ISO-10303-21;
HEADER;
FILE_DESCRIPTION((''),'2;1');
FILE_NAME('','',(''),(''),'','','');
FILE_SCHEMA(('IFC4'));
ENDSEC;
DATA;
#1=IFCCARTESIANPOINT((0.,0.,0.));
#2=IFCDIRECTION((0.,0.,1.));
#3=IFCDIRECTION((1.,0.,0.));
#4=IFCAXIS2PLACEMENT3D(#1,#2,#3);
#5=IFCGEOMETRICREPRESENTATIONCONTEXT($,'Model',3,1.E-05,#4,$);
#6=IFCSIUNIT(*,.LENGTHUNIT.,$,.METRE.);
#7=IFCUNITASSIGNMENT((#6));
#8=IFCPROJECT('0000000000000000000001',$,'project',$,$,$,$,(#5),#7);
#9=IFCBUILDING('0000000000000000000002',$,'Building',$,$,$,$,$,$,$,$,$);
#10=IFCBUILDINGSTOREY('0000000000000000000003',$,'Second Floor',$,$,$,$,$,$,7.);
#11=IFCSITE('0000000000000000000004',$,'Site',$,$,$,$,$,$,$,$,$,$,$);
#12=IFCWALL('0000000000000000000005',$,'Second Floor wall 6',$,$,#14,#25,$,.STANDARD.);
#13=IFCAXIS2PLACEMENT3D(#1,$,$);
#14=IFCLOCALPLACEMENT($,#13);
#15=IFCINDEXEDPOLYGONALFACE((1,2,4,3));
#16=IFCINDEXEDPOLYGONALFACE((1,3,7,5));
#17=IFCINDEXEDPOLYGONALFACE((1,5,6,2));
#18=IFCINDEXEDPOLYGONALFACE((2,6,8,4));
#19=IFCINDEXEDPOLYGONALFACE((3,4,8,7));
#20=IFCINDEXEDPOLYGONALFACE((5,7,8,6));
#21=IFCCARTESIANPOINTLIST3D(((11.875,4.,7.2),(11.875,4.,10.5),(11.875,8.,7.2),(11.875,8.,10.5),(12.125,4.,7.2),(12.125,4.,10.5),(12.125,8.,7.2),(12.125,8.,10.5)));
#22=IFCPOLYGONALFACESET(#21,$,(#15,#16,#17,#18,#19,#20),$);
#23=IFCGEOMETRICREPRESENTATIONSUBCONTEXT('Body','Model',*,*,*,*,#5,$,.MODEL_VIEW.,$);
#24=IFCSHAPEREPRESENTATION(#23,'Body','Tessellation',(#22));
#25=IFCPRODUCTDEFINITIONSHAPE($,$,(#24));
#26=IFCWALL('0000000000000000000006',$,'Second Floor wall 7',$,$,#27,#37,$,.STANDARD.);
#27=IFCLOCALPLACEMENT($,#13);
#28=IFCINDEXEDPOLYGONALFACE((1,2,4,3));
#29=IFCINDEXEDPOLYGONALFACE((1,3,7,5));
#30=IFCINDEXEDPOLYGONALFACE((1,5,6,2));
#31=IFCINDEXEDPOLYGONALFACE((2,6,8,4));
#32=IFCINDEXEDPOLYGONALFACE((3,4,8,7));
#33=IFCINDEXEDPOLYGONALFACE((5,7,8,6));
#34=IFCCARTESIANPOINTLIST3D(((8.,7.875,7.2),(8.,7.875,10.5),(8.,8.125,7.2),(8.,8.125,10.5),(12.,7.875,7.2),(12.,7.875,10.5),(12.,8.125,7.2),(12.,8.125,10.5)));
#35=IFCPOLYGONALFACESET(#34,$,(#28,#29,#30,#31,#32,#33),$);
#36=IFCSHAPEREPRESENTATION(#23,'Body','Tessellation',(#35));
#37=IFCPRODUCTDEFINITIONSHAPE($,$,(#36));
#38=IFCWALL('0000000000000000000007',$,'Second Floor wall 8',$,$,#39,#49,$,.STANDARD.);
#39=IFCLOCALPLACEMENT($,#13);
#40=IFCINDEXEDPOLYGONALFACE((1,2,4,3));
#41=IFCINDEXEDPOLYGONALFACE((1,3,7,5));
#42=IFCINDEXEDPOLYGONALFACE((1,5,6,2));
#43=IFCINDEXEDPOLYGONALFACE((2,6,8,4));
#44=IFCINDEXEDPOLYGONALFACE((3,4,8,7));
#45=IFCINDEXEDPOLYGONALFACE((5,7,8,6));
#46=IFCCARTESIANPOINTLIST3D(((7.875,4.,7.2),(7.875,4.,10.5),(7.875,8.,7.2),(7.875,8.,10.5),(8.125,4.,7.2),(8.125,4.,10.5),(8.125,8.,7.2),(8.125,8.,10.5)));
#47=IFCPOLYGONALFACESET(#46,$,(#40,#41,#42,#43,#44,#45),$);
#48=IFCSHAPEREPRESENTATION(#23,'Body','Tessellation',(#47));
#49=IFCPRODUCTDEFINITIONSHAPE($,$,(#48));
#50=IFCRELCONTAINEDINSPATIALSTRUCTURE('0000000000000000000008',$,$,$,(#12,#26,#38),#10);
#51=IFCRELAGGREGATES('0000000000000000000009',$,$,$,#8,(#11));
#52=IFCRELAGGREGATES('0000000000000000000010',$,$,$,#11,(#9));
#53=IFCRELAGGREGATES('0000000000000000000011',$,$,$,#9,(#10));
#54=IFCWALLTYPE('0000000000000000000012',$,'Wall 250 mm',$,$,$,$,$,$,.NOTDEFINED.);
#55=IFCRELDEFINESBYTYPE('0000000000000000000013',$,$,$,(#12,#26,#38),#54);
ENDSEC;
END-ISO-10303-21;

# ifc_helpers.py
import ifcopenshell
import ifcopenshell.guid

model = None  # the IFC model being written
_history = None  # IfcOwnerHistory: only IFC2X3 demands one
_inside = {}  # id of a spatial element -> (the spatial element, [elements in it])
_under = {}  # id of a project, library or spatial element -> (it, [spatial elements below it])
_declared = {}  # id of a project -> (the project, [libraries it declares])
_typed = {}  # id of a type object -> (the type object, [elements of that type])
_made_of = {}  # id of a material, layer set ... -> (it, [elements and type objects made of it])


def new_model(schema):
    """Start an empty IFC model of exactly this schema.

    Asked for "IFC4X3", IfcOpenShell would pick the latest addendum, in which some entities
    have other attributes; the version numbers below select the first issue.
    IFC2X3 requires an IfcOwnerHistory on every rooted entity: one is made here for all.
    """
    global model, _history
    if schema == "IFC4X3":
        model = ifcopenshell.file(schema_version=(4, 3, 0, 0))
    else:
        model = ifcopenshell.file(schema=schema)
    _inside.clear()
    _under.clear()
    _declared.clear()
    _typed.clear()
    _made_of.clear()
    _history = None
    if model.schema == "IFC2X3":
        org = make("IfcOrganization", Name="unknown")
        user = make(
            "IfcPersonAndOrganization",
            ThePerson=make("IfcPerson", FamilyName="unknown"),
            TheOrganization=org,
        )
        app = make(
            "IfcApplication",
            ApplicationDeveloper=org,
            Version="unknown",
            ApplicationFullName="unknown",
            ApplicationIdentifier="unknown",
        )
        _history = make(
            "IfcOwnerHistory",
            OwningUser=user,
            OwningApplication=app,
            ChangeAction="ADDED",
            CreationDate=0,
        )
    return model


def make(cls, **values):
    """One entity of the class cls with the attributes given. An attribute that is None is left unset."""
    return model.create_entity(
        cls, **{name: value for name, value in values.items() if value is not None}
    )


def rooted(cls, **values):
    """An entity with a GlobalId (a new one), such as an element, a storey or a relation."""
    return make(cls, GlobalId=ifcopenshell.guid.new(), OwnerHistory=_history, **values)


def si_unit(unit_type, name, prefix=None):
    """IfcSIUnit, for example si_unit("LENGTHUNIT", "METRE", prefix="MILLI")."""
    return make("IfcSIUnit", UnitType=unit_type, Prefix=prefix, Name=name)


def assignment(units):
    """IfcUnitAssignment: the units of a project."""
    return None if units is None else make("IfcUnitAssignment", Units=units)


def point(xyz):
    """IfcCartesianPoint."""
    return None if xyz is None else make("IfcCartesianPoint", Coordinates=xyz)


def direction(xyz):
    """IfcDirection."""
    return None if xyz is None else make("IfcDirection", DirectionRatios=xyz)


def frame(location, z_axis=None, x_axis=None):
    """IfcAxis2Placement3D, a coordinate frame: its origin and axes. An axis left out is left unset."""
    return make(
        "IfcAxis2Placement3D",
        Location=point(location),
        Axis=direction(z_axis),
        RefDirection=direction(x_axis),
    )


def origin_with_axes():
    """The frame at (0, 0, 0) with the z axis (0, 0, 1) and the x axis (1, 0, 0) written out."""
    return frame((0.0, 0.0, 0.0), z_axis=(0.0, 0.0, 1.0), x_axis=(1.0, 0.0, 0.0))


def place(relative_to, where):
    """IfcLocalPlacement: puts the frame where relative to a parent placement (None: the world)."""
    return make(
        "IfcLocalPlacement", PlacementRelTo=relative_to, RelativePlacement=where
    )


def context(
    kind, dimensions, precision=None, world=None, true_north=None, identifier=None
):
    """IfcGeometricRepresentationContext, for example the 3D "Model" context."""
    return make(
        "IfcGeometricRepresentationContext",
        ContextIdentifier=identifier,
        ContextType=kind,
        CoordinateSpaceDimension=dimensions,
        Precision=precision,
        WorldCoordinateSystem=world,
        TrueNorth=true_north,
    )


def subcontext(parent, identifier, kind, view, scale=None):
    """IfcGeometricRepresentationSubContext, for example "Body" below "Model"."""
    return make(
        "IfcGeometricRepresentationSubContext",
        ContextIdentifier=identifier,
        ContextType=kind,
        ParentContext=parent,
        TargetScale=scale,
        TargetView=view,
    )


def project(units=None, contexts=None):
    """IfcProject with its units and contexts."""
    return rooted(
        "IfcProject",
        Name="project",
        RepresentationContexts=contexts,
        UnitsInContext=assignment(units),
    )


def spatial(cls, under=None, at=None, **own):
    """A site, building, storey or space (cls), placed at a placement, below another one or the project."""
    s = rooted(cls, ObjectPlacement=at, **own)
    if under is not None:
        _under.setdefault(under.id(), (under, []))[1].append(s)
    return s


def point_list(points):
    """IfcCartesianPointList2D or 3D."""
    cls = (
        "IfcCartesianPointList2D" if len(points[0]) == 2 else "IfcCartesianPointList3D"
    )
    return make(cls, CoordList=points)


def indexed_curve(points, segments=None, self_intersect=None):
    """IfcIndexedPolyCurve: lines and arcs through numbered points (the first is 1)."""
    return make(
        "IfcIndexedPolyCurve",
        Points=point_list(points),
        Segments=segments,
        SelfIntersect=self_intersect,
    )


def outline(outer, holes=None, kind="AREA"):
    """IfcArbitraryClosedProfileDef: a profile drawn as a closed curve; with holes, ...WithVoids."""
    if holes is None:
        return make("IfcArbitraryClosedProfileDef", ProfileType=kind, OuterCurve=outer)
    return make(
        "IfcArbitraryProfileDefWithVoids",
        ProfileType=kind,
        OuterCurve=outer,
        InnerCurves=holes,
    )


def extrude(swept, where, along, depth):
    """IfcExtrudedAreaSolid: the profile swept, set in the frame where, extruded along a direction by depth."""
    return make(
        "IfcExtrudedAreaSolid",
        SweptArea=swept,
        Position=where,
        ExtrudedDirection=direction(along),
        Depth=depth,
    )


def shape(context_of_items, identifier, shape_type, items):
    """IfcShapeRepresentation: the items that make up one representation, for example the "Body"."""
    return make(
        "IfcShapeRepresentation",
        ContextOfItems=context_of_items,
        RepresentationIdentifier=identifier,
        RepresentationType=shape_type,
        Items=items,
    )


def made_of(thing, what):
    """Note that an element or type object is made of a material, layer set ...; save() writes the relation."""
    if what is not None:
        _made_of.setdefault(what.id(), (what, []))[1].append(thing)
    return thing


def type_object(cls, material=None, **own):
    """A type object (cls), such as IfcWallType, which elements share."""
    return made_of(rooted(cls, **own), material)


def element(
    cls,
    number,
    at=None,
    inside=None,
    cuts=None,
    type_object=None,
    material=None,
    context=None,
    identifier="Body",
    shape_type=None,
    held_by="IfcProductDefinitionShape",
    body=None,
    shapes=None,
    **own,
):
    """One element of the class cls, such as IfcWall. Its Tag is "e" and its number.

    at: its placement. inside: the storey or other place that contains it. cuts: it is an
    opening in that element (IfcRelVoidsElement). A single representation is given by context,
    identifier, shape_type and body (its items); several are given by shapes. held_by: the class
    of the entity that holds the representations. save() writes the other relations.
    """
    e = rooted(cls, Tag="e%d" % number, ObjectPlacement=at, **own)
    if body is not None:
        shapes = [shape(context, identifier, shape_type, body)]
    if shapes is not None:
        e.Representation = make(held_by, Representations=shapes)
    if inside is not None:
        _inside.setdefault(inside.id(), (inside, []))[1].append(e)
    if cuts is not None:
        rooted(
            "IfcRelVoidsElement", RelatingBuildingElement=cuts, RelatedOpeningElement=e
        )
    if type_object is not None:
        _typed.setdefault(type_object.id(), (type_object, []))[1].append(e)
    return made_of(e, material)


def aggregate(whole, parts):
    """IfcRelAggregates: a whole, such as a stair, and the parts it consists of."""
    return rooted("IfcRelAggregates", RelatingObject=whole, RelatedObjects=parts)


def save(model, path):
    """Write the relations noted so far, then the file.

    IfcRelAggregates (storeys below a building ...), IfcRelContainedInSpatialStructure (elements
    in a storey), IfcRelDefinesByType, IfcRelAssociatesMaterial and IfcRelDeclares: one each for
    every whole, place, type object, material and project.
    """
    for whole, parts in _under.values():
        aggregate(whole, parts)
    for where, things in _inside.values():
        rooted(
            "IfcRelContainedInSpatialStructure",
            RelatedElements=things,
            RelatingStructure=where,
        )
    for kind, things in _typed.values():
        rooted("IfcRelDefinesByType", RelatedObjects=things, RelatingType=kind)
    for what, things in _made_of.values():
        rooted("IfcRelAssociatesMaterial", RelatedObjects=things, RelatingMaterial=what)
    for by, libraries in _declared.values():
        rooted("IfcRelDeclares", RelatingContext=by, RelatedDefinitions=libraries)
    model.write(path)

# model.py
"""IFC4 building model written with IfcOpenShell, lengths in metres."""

from ifc_helpers import new_model, si_unit, frame, origin_with_axes, place, context, subcontext, project, spatial, indexed_curve, outline, extrude, type_object, element, save


model = new_model("IFC4")

# Units and contexts
model_context = context("Model", 3, precision=1e-05, world=origin_with_axes())
body_context = subcontext(model_context, "Body", "Model", "MODEL_VIEW")
ifc_project = project(units=[si_unit("LENGTHUNIT", "METRE")], contexts=[model_context])

# Site, building, storey
site = spatial("IfcSite", under=ifc_project, Name="Site")
building = spatial("IfcBuilding", under=site, Name="Building")
storey = spatial("IfcBuildingStorey", under=building, Name="Second Floor", Elevation=7.0)

# Walls
wall_type_1 = type_object("IfcWallType", Name="Wall 250 mm", PredefinedType="NOTDEFINED")
for number, where, z_axis, x_axis, name in (
    (1, (12.0, 4.0, 7.2), (0.0, 0.0, 1.0), (0.0, 1.0, 0.0), "Second Floor wall 6"),
    (2, (12.0, 8.0, 7.2), (0.0, 0.0, 1.0), (-1.0, 0.0, 0.0), "Second Floor wall 7"),
    (3, (8.0, 8.0, 7.2), (0.0, 0.0, 1.0), (0.0, -1.0, 0.0), "Second Floor wall 8"),
):
    element("IfcWall", number, at=place(None, frame(where, z_axis=z_axis, x_axis=x_axis)), inside=storey, type_object=wall_type_1, Name=name, PredefinedType="STANDARD", context=body_context, shape_type="SweptSolid", body=[
        extrude(outline(indexed_curve([(0.0, 0.0), (0.0, 0.25), (4.0, 0.25), (4.0, 0.0), (0.0, 0.0)], self_intersect=False)), frame((0.0, -0.125, 0.0), z_axis=(0.0, 0.0, 1.0), x_axis=(1.0, 0.0, 0.0)), (0.0, 0.0, 1.0), 3.3),
    ])

save(model, "model.ifc")
